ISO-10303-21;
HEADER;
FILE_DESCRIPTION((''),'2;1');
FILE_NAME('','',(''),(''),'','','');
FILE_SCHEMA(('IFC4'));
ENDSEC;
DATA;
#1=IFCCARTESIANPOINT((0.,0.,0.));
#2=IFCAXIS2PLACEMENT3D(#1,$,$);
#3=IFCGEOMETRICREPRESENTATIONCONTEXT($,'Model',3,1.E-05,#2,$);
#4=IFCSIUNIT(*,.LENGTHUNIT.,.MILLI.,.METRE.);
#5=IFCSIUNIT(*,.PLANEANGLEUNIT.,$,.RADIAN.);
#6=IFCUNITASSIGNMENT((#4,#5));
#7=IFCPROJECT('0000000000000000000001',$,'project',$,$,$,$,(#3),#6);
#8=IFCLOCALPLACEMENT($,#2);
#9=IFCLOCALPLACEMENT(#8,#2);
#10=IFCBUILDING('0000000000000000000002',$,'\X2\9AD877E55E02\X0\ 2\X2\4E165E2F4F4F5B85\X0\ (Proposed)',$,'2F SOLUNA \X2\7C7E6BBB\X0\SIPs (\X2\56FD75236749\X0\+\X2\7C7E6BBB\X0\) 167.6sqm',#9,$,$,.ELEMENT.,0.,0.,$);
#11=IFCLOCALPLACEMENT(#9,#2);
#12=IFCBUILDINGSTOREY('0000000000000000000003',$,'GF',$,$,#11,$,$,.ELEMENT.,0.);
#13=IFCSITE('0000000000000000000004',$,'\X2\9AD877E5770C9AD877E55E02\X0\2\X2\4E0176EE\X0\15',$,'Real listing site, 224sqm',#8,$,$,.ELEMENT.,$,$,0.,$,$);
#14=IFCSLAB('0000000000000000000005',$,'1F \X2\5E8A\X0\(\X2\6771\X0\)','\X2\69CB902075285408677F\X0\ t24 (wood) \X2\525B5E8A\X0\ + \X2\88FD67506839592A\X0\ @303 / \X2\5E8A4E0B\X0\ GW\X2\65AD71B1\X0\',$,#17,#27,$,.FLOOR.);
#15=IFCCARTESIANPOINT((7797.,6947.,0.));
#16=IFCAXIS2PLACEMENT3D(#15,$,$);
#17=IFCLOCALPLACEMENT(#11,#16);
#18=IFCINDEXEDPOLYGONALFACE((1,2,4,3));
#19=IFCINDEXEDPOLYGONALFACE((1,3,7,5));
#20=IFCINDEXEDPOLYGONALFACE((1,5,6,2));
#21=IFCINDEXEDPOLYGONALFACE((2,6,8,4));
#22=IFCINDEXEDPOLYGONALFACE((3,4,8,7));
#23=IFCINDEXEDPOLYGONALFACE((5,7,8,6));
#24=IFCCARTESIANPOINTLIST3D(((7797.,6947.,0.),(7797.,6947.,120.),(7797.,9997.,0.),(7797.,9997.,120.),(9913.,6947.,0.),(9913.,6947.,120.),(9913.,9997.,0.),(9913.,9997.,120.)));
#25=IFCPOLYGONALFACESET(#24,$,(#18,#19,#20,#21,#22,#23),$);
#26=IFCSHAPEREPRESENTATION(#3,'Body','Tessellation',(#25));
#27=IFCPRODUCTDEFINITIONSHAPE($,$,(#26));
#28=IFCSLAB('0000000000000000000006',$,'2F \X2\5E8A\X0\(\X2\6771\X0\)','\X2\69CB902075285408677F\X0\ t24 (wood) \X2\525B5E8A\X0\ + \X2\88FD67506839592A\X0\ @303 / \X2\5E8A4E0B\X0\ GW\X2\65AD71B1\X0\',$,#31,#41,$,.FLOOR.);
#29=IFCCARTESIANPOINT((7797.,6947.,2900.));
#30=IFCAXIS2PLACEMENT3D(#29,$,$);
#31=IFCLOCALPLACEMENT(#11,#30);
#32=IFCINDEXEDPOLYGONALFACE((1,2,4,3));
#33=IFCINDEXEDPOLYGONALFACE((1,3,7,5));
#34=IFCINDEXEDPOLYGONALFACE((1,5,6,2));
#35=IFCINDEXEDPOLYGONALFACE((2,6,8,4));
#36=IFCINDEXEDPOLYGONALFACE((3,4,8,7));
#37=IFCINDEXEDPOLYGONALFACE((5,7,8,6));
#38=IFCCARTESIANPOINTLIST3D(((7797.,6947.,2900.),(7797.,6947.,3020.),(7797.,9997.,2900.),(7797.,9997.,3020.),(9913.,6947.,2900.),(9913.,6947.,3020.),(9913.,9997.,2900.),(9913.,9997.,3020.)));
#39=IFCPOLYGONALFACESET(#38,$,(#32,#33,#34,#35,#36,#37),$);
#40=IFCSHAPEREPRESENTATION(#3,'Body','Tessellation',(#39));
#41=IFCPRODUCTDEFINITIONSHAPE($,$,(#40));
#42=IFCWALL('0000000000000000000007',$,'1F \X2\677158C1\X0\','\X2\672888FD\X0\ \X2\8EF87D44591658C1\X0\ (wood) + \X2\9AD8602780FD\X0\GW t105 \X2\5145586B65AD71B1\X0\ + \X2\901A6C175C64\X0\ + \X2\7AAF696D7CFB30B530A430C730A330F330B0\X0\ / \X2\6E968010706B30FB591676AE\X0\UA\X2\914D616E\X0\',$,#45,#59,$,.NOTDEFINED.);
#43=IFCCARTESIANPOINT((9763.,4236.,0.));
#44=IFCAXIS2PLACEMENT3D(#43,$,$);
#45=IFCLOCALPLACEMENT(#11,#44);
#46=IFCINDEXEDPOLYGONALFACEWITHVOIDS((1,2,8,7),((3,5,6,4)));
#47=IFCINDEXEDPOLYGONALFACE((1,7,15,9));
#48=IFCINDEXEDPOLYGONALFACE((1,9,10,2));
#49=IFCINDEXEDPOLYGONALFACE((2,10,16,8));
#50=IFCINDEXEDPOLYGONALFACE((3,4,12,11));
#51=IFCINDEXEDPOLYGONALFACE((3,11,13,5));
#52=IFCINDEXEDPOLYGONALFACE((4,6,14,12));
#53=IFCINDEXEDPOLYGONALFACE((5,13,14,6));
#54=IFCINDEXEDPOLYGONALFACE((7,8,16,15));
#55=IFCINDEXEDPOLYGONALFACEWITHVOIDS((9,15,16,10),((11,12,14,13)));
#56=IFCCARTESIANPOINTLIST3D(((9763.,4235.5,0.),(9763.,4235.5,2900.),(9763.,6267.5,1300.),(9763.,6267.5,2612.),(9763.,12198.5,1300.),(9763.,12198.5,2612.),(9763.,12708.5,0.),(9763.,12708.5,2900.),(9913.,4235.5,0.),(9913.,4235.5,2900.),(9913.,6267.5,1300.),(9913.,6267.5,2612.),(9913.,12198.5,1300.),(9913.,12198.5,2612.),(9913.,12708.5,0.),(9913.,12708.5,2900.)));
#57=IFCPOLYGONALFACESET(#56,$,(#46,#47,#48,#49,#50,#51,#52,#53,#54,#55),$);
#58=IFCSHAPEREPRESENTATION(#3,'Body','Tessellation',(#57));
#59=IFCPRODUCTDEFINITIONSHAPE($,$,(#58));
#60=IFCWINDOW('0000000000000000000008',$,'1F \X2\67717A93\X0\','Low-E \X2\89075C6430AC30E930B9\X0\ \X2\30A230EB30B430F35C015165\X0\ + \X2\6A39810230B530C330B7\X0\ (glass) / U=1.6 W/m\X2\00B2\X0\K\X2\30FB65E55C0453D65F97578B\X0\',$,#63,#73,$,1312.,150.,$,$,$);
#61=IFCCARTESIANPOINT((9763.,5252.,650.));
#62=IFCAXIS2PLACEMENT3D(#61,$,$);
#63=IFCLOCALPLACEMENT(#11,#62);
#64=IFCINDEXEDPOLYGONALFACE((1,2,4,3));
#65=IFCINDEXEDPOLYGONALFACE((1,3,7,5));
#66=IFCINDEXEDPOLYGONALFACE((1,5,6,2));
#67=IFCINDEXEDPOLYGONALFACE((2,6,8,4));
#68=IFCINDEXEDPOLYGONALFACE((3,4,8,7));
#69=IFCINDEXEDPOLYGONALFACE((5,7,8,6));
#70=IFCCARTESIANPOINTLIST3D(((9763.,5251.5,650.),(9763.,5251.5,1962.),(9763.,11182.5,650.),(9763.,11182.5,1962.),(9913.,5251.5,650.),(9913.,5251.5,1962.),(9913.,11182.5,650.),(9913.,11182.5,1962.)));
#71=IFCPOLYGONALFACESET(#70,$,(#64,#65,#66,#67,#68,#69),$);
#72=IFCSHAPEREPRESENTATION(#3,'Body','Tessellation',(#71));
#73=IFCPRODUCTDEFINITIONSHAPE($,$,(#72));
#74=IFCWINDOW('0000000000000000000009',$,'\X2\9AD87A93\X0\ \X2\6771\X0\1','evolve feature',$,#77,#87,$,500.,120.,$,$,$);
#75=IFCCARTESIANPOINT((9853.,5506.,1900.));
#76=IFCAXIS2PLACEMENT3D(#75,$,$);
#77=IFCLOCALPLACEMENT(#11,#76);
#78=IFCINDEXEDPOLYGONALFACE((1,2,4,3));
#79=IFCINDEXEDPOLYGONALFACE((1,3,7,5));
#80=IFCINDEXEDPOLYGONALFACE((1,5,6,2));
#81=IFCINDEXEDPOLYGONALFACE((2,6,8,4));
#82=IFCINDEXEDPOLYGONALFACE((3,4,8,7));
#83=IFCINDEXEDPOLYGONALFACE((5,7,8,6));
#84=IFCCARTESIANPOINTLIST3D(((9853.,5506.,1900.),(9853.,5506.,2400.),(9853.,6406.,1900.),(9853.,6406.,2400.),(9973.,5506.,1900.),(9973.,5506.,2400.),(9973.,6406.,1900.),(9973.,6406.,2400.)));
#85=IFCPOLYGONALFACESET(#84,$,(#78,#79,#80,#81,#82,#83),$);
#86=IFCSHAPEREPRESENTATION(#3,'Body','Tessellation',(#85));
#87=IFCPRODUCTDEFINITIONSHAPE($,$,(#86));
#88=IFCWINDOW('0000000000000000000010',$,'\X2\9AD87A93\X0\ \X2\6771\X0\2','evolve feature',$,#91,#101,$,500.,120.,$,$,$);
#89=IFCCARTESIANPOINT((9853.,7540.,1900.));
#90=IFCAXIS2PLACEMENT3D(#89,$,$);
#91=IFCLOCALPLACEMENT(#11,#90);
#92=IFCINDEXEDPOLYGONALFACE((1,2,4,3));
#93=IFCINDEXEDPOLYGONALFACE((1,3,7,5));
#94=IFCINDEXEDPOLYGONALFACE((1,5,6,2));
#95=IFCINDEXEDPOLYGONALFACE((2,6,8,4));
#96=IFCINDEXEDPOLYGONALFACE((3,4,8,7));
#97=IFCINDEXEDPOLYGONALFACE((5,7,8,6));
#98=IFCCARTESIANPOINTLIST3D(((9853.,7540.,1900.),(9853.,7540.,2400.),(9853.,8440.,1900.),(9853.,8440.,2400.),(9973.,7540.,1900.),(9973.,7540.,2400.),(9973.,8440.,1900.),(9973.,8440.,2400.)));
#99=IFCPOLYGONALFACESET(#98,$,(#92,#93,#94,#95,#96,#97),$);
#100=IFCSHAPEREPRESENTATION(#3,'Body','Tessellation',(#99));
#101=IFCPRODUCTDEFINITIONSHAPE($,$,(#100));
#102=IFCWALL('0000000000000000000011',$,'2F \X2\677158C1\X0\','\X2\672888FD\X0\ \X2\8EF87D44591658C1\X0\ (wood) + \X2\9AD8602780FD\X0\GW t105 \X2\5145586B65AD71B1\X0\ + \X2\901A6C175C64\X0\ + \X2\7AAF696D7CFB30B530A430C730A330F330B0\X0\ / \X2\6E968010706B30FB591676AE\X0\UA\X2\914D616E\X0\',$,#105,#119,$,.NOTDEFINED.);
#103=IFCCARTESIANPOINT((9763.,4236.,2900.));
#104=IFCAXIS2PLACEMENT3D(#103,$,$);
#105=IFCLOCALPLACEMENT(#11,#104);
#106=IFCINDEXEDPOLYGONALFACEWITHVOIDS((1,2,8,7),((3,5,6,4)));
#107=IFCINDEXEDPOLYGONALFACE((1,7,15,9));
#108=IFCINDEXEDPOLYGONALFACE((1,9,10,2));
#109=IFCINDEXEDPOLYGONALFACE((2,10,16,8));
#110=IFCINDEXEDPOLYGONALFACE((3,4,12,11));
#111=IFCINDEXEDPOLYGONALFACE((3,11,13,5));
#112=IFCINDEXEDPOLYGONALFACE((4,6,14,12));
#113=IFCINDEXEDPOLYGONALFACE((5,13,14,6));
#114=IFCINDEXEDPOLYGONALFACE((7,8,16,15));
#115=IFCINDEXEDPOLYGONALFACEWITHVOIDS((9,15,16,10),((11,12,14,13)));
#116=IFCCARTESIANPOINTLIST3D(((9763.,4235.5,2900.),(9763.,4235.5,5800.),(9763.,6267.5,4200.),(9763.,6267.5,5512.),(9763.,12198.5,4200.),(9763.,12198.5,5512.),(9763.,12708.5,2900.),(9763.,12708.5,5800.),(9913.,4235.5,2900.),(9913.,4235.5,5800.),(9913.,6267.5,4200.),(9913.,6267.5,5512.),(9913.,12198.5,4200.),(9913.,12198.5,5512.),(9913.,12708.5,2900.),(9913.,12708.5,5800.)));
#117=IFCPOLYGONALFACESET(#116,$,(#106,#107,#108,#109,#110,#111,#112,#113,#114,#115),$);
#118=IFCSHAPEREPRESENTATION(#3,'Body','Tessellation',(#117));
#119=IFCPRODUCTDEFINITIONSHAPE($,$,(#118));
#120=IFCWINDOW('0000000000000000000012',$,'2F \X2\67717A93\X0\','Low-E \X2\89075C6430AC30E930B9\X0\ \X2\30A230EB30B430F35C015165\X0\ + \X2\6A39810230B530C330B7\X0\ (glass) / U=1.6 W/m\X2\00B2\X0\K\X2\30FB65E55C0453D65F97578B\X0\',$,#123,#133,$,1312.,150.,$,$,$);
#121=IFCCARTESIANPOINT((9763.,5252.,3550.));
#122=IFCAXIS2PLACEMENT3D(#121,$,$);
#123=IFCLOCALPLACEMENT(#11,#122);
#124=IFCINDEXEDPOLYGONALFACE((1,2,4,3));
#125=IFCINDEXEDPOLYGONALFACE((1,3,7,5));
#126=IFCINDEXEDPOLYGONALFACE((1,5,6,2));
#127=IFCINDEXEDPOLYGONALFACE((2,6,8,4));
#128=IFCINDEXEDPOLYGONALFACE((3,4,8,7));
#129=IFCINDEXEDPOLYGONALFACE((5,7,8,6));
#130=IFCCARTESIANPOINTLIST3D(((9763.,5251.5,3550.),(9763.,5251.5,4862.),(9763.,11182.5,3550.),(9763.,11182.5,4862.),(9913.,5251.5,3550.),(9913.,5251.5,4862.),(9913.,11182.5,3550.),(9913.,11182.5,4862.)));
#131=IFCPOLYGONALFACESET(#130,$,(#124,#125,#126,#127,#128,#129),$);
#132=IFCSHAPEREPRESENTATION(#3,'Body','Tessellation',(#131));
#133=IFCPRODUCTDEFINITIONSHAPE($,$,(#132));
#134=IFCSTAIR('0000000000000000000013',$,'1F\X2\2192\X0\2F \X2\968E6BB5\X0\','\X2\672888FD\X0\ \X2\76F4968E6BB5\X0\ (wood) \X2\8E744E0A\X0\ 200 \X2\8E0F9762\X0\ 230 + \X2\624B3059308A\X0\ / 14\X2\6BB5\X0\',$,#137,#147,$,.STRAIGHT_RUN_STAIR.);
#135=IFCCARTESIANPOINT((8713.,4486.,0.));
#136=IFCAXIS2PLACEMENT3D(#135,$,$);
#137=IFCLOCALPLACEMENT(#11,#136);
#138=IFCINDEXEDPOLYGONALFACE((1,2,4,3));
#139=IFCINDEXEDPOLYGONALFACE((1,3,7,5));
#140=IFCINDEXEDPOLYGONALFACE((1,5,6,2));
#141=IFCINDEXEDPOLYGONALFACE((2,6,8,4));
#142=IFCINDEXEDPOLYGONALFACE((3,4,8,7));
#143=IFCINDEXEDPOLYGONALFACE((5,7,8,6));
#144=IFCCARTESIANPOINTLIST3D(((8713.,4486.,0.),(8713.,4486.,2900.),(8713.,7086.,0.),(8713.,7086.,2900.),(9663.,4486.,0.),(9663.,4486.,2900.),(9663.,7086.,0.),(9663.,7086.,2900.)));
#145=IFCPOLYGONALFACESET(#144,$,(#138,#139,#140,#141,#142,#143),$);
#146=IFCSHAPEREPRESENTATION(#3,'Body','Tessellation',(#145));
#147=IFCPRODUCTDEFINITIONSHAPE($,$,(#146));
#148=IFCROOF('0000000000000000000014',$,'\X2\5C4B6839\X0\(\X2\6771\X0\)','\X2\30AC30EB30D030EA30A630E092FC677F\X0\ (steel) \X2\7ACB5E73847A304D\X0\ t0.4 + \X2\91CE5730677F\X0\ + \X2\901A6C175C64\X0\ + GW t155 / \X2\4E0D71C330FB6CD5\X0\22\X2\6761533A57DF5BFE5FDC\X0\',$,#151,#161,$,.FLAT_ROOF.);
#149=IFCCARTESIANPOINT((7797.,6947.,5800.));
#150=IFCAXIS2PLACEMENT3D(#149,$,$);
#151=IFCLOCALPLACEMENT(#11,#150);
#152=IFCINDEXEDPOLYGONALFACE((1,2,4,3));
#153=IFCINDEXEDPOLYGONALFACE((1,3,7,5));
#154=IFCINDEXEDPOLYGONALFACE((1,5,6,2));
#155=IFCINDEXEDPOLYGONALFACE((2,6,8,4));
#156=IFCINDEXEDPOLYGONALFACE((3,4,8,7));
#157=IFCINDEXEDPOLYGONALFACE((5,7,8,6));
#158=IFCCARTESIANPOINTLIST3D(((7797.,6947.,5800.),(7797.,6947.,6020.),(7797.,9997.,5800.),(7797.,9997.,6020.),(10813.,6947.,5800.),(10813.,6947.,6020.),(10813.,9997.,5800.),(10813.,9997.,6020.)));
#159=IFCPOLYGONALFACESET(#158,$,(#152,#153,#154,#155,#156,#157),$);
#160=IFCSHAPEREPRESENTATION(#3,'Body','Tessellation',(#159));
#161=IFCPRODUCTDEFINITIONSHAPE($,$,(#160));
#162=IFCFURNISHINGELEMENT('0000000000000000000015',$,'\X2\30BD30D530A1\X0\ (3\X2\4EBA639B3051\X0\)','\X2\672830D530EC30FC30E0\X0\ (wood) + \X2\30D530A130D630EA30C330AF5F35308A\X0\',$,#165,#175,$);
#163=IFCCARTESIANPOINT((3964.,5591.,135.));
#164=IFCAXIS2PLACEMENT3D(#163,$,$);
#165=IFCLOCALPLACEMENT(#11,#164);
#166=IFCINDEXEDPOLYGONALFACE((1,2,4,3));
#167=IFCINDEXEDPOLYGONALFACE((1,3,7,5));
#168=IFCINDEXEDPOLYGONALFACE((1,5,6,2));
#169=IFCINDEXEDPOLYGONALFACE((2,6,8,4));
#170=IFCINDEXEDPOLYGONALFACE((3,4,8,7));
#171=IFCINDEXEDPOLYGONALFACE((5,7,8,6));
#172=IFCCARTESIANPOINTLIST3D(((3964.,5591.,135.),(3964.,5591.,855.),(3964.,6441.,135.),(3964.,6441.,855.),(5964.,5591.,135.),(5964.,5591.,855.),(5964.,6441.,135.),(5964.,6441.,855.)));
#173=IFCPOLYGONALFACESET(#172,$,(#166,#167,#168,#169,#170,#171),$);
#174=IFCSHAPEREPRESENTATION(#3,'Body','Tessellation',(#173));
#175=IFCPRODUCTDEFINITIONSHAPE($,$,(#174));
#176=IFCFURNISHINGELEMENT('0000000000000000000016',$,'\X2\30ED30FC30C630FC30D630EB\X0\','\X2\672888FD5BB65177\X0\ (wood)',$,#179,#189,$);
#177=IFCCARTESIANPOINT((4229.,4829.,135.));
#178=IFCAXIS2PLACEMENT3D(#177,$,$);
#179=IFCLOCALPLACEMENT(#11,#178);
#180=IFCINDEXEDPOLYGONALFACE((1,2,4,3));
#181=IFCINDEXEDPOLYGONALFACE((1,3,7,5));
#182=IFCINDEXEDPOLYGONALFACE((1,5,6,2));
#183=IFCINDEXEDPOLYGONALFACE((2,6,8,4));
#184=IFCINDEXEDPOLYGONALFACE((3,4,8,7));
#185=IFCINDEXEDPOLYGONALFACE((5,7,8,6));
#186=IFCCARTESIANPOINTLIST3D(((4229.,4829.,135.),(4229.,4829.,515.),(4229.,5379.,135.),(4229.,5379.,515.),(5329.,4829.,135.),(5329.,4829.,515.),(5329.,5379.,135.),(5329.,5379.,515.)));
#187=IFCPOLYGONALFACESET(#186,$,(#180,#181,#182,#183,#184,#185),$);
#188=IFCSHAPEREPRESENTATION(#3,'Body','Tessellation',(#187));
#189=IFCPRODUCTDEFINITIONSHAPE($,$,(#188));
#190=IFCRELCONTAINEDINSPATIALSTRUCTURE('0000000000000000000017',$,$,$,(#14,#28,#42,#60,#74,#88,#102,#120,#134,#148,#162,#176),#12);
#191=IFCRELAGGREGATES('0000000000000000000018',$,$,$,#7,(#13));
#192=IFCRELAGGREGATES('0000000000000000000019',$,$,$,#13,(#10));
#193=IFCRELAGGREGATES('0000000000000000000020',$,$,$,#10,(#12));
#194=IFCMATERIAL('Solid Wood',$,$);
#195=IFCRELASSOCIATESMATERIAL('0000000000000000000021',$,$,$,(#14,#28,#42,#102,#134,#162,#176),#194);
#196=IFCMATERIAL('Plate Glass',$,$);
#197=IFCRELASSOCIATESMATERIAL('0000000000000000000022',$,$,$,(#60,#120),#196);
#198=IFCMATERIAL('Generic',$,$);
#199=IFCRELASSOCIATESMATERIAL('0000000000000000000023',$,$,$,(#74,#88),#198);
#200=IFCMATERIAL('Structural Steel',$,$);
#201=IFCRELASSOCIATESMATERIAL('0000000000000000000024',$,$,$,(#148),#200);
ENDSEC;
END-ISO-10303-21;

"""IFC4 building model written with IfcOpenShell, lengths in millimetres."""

from ifc_helpers import new_model, si_unit, frame, frame_2d, origin, place, context, project, spatial, rectangle, extrude, material, element, fill, save


model = new_model("IFC4")

# Units and contexts
model_context = context("Model", 3, precision=1e-05, world=origin())
ifc_project = project(units=[si_unit("LENGTHUNIT", "METRE", prefix="MILLI"), si_unit("PLANEANGLEUNIT", "RADIAN")], contexts=[model_context])

# Site, building, storey
site_placement = place(None, origin())
site = spatial("IfcSite", under=ifc_project, at=site_placement, Name="高知県高知市2丁目15", ObjectType="Real listing site, 224sqm", CompositionType="ELEMENT", RefElevation=0.0)
building_placement = place(site_placement, origin())
building = spatial("IfcBuilding", under=site, at=building_placement, Name="高知市 2世帯住宅 (Proposed)", ObjectType="2F SOLUNA 籾殻SIPs (国産杉+籾殻) 167.6sqm", CompositionType="ELEMENT", ElevationOfRefHeight=0.0, ElevationOfTerrain=0.0)
storey_placement = place(building_placement, origin())
storey = spatial("IfcBuildingStorey", under=building, at=storey_placement, Name="GF", CompositionType="ELEMENT", Elevation=0.0)

# Slabs
ifc_material_1 = material(Name="Solid Wood")
slab_1_placement = place(storey_placement, frame((7797.0, 6947.0, 0.0)))
element("IfcSlab", 1, at=slab_1_placement, inside=storey, material=ifc_material_1, Name="1F 床(東)", Description="構造用合板 t24 (wood) 剛床 + 製材根太 @303 / 床下 GW断熱", PredefinedType="FLOOR", context=model_context, shape_type="SweptSolid", body=[
    extrude(rectangle(XDim=2116.0, YDim=3050.0, at=frame_2d((1058.0, 1525.0))), frame((7797.0, 6947.0, 0.0)), (0.0, 0.0, 1.0), 120.0),
])
slab_2_placement = place(storey_placement, frame((7797.0, 6947.0, 2900.0)))
element("IfcSlab", 2, at=slab_2_placement, inside=storey, material=ifc_material_1, Name="2F 床(東)", Description="構造用合板 t24 (wood) 剛床 + 製材根太 @303 / 床下 GW断熱", PredefinedType="FLOOR", context=model_context, shape_type="SweptSolid", body=[
    extrude(rectangle(XDim=2116.0, YDim=3050.0, at=frame_2d((1058.0, 1525.0))), frame((7797.0, 6947.0, 2900.0)), (0.0, 0.0, 1.0), 120.0),
])

# Wall, openings, windows
wall_1_placement = place(storey_placement, frame((9763.0, 4236.0, 0.0)))
wall_1 = element("IfcWall", 3, at=wall_1_placement, inside=storey, material=ifc_material_1, Name="1F 東壁", Description="木製 軸組外壁 (wood) + 高性能GW t105 充填断熱 + 通気層 + 窯業系サイディング / 準耐火・外皮UA配慮", PredefinedType="NOTDEFINED", context=model_context, shape_type="SweptSolid", body=[
    extrude(rectangle(XDim=150.0, YDim=8473.0, at=frame_2d((75.0, 4236.0))), frame((9763.0, 4236.0, 0.0)), (0.0, 0.0, 1.0), 2900.0),
])
opening_1_placement = place(storey_placement, frame((9763.0, 5252.0, 650.0)))
opening_1 = element("IfcOpeningElement", 4, at=opening_1_placement, cuts=wall_1, PredefinedType="NOTDEFINED", context=model_context, shape_type="SweptSolid", body=[
    extrude(rectangle(XDim=150.0, YDim=5931.0, at=frame_2d((75.0, 2965.0))), frame((9763.0, 5252.0, 650.0)), (0.0, 0.0, 1.0), 1312.0),
])
opening_2_placement = place(storey_placement, frame((9853.0, 5506.0, 1900.0)))
opening_2 = element("IfcOpeningElement", 5, at=opening_2_placement, cuts=wall_1, PredefinedType="NOTDEFINED", context=model_context, shape_type="SweptSolid", body=[
    extrude(rectangle(XDim=120.0, YDim=900.0, at=frame_2d((60.0, 450.0))), frame((9853.0, 5506.0, 1900.0)), (0.0, 0.0, 1.0), 500.0),
])
opening_3_placement = place(storey_placement, frame((9853.0, 7540.0, 1900.0)))
opening_3 = element("IfcOpeningElement", 6, at=opening_3_placement, cuts=wall_1, PredefinedType="NOTDEFINED", context=model_context, shape_type="SweptSolid", body=[
    extrude(rectangle(XDim=120.0, YDim=900.0, at=frame_2d((60.0, 450.0))), frame((9853.0, 7540.0, 1900.0)), (0.0, 0.0, 1.0), 500.0),
])
ifc_material_2 = material(Name="Plate Glass")
window_1_placement = place(storey_placement, frame((9763.0, 5252.0, 650.0)))
window_1 = element("IfcWindow", 7, at=window_1_placement, inside=storey, material=ifc_material_2, Name="1F 東窓", Description="Low-E 複層ガラス アルゴン封入 + 樹脂サッシ (glass) / U=1.6 W/m²K・日射取得型", OverallHeight=1312.0, OverallWidth=150.0, context=model_context, shape_type="SweptSolid", body=[
    extrude(rectangle(XDim=150.0, YDim=5931.0, at=frame_2d((75.0, 2965.0))), frame((9763.0, 5252.0, 650.0)), (0.0, 0.0, 1.0), 1312.0),
])
fill(opening_1, window_1)
ifc_material_3 = material(Name="Generic")
window_2_placement = place(storey_placement, frame((9853.0, 5506.0, 1900.0)))
window_2 = element("IfcWindow", 8, at=window_2_placement, inside=storey, material=ifc_material_3, Name="高窓 東1", Description="evolve feature", OverallHeight=500.0, OverallWidth=120.0, context=model_context, shape_type="SweptSolid", body=[
    extrude(rectangle(XDim=120.0, YDim=900.0, at=frame_2d((60.0, 450.0))), frame((9853.0, 5506.0, 1900.0)), (0.0, 0.0, 1.0), 500.0),
])
fill(opening_2, window_2)
window_3_placement = place(storey_placement, frame((9853.0, 7540.0, 1900.0)))
window_3 = element("IfcWindow", 9, at=window_3_placement, inside=storey, material=ifc_material_3, Name="高窓 東2", Description="evolve feature", OverallHeight=500.0, OverallWidth=120.0, context=model_context, shape_type="SweptSolid", body=[
    extrude(rectangle(XDim=120.0, YDim=900.0, at=frame_2d((60.0, 450.0))), frame((9853.0, 7540.0, 1900.0)), (0.0, 0.0, 1.0), 500.0),
])
fill(opening_3, window_3)

# Wall, opening, window
wall_2_placement = place(storey_placement, frame((9763.0, 4236.0, 2900.0)))
wall_2 = element("IfcWall", 10, at=wall_2_placement, inside=storey, material=ifc_material_1, Name="2F 東壁", Description="木製 軸組外壁 (wood) + 高性能GW t105 充填断熱 + 通気層 + 窯業系サイディング / 準耐火・外皮UA配慮", PredefinedType="NOTDEFINED", context=model_context, shape_type="SweptSolid", body=[
    extrude(rectangle(XDim=150.0, YDim=8473.0, at=frame_2d((75.0, 4236.0))), frame((9763.0, 4236.0, 2900.0)), (0.0, 0.0, 1.0), 2900.0),
])
opening_4_placement = place(storey_placement, frame((9763.0, 5252.0, 3550.0)))
opening_4 = element("IfcOpeningElement", 11, at=opening_4_placement, cuts=wall_2, PredefinedType="NOTDEFINED", context=model_context, shape_type="SweptSolid", body=[
    extrude(rectangle(XDim=150.0, YDim=5931.0, at=frame_2d((75.0, 2965.0))), frame((9763.0, 5252.0, 3550.0)), (0.0, 0.0, 1.0), 1312.0),
])
window_4_placement = place(storey_placement, frame((9763.0, 5252.0, 3550.0)))
window_4 = element("IfcWindow", 12, at=window_4_placement, inside=storey, material=ifc_material_2, Name="2F 東窓", Description="Low-E 複層ガラス アルゴン封入 + 樹脂サッシ (glass) / U=1.6 W/m²K・日射取得型", OverallHeight=1312.0, OverallWidth=150.0, context=model_context, shape_type="SweptSolid", body=[
    extrude(rectangle(XDim=150.0, YDim=5931.0, at=frame_2d((75.0, 2965.0))), frame((9763.0, 5252.0, 3550.0)), (0.0, 0.0, 1.0), 1312.0),
])
fill(opening_4, window_4)

# Stair
stair_placement = place(storey_placement, frame((8713.0, 4486.0, 0.0)))
element("IfcStair", 13, at=stair_placement, inside=storey, material=ifc_material_1, Name="1F→2F 階段", Description="木製 直階段 (wood) 蹴上 200 踏面 230 + 手すり / 14段", PredefinedType="STRAIGHT_RUN_STAIR", context=model_context, shape_type="SweptSolid", body=[
    extrude(rectangle(XDim=950.0, YDim=2600.0, at=frame_2d((475.0, 1300.0))), frame((8713.0, 4486.0, 0.0)), (0.0, 0.0, 1.0), 2900.0),
])

# Roof
ifc_material_4 = material(Name="Structural Steel")
roof_placement = place(storey_placement, frame((7797.0, 6947.0, 5800.0)))
element("IfcRoof", 14, at=roof_placement, inside=storey, material=ifc_material_4, Name="屋根(東)", Description="ガルバリウム鋼板 (steel) 立平葺き t0.4 + 野地板 + 通気層 + GW t155 / 不燃・法22条区域対応", PredefinedType="FLAT_ROOF", context=model_context, shape_type="SweptSolid", body=[
    extrude(rectangle(XDim=3016.0, YDim=3050.0, at=frame_2d((1508.0, 1525.0))), frame((7797.0, 6947.0, 5800.0)), (0.0, 0.0, 1.0), 220.0),
])

# Furnishing elements
furnishing_1_placement = place(storey_placement, frame((3964.0, 5591.0, 135.0)))
element("IfcFurnishingElement", 15, at=furnishing_1_placement, inside=storey, material=ifc_material_1, Name="ソファ (3人掛け)", Description="木フレーム (wood) + ファブリック張り", context=model_context, shape_type="SweptSolid", body=[
    extrude(rectangle(XDim=2000.0, YDim=850.0, at=frame_2d((1000.0, 425.0))), frame((3964.0, 5591.0, 135.0)), (0.0, 0.0, 1.0), 720.0),
])
furnishing_2_placement = place(storey_placement, frame((4229.0, 4829.0, 135.0)))
element("IfcFurnishingElement", 16, at=furnishing_2_placement, inside=storey, material=ifc_material_1, Name="ローテーブル", Description="木製家具 (wood)", context=model_context, shape_type="SweptSolid", body=[
    extrude(rectangle(XDim=1100.0, YDim=550.0, at=frame_2d((550.0, 275.0))), frame((4229.0, 4829.0, 135.0)), (0.0, 0.0, 1.0), 380.0),
])

save(model, "model.ifc")
